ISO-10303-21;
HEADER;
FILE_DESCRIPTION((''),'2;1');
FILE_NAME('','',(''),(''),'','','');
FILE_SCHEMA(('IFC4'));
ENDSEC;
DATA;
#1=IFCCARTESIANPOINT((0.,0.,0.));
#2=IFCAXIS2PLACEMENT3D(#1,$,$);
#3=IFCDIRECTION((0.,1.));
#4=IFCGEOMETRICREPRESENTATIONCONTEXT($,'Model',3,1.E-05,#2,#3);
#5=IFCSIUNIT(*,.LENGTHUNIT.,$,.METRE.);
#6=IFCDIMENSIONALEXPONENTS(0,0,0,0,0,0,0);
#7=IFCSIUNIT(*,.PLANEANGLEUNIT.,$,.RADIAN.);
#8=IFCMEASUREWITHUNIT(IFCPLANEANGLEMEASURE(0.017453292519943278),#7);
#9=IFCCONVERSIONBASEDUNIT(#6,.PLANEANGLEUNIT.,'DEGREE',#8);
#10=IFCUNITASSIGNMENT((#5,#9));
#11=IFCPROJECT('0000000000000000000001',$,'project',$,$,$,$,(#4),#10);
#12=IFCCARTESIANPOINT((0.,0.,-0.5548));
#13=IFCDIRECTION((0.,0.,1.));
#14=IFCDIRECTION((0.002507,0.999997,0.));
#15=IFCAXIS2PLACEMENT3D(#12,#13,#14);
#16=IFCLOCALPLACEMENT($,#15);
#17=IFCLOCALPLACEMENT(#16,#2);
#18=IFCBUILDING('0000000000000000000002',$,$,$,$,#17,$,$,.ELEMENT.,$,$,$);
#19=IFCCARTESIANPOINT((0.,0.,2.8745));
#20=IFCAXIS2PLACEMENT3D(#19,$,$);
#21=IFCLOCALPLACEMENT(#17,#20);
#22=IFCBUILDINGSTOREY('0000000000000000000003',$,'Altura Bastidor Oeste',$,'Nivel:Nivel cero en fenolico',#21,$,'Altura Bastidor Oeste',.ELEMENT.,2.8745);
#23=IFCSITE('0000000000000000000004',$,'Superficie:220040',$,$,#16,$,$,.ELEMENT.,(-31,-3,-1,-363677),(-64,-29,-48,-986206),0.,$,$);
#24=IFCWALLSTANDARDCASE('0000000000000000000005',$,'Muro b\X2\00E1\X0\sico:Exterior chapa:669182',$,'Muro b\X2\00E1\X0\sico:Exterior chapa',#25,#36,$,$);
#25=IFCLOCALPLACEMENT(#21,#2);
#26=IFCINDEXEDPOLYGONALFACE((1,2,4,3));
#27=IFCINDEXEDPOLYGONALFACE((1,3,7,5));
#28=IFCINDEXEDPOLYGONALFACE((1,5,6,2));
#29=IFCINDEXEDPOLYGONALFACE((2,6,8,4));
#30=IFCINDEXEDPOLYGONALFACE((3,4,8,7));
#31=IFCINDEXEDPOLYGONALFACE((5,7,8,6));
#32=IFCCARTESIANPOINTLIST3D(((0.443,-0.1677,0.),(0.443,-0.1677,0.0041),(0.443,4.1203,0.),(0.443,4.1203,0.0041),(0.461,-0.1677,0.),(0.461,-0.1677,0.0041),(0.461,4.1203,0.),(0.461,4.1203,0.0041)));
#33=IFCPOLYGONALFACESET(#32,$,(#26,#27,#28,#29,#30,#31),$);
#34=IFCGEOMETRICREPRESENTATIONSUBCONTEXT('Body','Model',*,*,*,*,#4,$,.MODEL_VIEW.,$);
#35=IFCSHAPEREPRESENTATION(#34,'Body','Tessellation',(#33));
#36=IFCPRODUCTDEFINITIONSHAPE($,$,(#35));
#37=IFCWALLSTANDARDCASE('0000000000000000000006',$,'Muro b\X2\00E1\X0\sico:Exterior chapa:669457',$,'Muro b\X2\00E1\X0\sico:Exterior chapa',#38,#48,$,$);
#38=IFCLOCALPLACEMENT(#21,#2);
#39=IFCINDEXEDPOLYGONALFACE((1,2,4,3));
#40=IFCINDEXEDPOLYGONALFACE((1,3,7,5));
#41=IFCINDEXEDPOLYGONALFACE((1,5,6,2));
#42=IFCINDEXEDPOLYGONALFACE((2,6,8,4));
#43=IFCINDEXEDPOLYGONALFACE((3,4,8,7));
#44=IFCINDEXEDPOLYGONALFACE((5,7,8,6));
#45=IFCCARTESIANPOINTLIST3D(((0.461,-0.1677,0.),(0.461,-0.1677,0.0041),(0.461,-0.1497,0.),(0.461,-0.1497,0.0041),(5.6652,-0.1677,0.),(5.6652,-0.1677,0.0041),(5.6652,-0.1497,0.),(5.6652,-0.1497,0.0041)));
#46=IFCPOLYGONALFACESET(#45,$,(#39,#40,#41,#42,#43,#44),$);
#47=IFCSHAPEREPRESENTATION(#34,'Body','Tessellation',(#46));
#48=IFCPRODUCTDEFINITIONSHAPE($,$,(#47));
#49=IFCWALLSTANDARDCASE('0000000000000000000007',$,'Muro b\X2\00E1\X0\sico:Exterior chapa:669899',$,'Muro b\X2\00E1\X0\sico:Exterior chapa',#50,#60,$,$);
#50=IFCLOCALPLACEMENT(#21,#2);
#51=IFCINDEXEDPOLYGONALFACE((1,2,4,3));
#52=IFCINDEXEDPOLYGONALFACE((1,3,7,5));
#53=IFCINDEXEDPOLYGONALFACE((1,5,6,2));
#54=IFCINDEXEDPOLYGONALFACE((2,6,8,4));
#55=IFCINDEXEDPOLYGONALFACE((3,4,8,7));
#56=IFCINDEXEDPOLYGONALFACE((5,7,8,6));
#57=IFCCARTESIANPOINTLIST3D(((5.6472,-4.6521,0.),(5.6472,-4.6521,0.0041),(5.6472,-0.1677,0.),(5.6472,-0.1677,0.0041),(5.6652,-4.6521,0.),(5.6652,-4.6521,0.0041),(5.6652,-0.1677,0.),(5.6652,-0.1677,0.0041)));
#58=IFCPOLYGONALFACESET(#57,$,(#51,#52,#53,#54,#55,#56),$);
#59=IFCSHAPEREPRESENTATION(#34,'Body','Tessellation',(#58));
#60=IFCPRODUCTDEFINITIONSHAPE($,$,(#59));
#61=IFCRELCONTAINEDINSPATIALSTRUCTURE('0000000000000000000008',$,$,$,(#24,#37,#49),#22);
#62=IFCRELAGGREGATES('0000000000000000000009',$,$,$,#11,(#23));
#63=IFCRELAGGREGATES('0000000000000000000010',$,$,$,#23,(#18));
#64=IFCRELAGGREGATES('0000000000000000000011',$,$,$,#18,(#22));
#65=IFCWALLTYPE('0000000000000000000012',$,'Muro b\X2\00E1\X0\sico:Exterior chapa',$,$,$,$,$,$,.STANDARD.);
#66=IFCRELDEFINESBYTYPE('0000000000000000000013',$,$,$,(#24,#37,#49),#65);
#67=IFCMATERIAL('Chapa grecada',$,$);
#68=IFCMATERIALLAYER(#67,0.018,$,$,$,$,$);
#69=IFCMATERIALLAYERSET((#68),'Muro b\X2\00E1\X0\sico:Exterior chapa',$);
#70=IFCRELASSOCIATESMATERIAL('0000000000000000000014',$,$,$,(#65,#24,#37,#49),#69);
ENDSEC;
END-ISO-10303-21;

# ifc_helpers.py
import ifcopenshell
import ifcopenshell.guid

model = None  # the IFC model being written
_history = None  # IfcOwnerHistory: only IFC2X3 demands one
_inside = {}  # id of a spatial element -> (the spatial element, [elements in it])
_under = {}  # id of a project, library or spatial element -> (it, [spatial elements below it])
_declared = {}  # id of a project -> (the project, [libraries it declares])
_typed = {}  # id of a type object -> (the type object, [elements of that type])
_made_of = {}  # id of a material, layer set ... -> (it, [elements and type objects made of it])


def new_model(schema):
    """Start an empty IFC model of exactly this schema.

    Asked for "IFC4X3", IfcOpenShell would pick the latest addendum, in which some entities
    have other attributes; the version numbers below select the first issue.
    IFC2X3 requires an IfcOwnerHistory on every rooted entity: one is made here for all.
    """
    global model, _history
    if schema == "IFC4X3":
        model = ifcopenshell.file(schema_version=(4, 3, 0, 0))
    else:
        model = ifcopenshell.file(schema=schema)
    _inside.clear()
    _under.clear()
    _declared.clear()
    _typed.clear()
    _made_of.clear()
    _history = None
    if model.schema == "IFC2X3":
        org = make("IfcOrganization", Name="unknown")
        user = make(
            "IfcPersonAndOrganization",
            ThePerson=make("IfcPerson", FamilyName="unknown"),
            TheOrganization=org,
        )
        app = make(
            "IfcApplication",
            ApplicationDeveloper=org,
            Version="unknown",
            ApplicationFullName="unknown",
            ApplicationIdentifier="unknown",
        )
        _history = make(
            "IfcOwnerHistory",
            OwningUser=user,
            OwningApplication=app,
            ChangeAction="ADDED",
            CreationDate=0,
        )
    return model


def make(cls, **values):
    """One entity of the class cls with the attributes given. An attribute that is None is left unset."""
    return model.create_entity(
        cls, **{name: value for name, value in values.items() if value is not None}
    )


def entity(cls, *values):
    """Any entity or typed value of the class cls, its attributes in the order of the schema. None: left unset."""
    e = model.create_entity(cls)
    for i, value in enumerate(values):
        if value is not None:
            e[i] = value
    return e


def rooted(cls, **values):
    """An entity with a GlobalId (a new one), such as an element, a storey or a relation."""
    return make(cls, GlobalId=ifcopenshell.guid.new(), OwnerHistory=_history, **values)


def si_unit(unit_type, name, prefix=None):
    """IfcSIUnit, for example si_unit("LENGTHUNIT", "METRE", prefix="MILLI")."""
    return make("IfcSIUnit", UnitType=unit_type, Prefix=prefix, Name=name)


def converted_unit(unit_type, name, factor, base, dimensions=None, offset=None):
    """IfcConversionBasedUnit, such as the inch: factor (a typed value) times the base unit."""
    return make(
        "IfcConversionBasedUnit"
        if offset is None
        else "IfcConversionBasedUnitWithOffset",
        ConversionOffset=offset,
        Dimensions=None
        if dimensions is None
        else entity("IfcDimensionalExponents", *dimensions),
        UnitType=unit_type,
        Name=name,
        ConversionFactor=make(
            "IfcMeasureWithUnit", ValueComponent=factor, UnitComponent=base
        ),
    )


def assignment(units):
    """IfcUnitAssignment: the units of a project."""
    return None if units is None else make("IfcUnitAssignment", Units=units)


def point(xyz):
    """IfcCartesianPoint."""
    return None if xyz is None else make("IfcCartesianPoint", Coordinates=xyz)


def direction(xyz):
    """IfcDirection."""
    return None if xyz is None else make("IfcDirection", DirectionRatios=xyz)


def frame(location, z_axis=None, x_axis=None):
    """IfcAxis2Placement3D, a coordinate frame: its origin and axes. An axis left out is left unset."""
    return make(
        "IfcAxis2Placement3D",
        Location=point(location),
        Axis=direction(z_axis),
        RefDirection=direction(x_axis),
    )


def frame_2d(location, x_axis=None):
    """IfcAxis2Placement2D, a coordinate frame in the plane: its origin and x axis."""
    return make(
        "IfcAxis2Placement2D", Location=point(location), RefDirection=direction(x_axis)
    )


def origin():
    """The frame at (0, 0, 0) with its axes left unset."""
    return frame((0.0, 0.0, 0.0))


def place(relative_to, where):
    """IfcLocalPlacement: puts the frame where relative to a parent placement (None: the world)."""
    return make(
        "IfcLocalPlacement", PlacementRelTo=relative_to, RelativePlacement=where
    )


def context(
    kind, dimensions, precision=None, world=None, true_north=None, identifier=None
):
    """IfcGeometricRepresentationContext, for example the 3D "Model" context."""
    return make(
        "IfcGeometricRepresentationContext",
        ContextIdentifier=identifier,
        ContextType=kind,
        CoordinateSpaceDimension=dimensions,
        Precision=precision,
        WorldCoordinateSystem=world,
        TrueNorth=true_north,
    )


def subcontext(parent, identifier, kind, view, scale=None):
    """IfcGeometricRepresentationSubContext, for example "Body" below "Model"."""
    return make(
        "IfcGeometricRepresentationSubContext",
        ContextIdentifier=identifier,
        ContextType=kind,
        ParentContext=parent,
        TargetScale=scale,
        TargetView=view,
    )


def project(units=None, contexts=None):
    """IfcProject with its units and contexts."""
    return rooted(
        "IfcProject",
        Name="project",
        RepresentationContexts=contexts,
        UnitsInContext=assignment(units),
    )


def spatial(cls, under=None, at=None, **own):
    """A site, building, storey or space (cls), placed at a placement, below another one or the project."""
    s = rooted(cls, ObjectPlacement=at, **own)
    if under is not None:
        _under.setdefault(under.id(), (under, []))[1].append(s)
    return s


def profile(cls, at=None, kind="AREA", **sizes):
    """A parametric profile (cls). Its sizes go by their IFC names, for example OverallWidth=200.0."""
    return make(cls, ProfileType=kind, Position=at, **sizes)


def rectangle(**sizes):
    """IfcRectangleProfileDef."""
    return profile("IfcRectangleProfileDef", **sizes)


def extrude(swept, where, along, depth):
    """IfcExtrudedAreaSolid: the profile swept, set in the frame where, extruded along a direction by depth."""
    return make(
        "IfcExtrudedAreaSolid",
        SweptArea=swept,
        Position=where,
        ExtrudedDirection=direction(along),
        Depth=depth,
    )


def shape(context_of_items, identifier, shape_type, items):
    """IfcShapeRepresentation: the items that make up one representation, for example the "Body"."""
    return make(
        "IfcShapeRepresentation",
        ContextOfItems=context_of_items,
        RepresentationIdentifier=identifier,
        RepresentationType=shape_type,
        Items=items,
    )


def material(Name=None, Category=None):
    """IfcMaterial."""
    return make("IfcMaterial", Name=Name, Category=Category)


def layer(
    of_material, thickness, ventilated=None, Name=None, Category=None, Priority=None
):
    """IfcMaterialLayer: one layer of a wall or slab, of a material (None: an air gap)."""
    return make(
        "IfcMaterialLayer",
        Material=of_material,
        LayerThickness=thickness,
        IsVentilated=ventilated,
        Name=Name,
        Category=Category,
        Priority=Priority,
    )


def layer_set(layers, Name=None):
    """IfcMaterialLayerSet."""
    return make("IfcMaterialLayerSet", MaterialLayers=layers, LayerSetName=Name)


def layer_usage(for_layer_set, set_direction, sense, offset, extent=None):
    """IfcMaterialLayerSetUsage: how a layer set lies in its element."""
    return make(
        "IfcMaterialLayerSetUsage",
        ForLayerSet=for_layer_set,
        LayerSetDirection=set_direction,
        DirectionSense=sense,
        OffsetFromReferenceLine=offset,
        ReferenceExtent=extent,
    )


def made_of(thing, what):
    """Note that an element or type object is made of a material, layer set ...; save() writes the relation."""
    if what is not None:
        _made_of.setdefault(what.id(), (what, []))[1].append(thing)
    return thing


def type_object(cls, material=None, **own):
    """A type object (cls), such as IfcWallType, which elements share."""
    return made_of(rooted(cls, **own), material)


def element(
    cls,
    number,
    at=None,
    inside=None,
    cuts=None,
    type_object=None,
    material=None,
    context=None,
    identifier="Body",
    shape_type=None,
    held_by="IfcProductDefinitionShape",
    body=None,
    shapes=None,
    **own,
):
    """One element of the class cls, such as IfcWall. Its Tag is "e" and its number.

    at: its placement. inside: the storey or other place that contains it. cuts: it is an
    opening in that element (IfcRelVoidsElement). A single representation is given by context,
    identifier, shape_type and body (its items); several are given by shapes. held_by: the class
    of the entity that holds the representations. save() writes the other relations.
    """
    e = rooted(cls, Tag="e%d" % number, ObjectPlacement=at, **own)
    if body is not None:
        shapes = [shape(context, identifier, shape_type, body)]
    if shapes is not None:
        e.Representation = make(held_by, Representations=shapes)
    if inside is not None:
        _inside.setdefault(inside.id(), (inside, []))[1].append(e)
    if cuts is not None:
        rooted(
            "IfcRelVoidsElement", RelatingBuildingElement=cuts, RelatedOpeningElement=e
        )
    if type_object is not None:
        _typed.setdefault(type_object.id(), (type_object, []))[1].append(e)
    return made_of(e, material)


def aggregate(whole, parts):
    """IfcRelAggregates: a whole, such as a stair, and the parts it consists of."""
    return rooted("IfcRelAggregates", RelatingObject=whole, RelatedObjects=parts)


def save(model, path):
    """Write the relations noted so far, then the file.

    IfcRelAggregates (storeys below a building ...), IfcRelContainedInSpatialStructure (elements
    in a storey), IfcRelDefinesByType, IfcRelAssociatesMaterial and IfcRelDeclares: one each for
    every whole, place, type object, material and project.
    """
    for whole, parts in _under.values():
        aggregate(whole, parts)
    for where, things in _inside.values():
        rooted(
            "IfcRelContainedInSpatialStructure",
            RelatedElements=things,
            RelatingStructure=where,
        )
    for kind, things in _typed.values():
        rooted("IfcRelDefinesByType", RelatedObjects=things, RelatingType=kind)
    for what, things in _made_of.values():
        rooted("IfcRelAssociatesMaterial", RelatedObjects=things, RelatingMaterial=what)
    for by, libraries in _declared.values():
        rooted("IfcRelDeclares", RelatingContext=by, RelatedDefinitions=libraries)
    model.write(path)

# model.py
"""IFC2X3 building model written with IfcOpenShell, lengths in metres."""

from ifc_helpers import new_model, entity, si_unit, converted_unit, direction, frame, frame_2d, origin, place, context, subcontext, project, spatial, rectangle, extrude, material, layer, layer_set, layer_usage, type_object, element, save


model = new_model("IFC2X3")

# Units and contexts
model_context = context("Model", 3, precision=1e-05, world=origin(), true_north=direction((0.0, 1.0)))
body_context = subcontext(model_context, "Body", "Model", "MODEL_VIEW")
ifc_project = project(units=[si_unit("LENGTHUNIT", "METRE"), converted_unit("PLANEANGLEUNIT", "DEGREE", entity("IfcPlaneAngleMeasure", 0.017453292519943278), si_unit("PLANEANGLEUNIT", "RADIAN"), dimensions=[0, 0, 0, 0, 0, 0, 0])], contexts=[model_context])

# Site, building, storey
site_placement = place(None, frame((0.0, 0.0, -0.5548), z_axis=(0.0, 0.0, 1.0), x_axis=(0.002507, 0.999997, 0.0)))
site = spatial("IfcSite", under=ifc_project, at=site_placement, Name="Superficie:220040", CompositionType="ELEMENT", RefLatitude=(-31, -3, -1, -363677), RefLongitude=(-64, -29, -48, -986206), RefElevation=0.0)
building_placement = place(site_placement, origin())
building = spatial("IfcBuilding", under=site, at=building_placement, CompositionType="ELEMENT")
storey_placement = place(building_placement, frame((0.0, 0.0, 2.8745)))
storey = spatial("IfcBuildingStorey", under=building, at=storey_placement, Name="Altura Bastidor Oeste", ObjectType="Nivel:Nivel cero en fenolico", LongName="Altura Bastidor Oeste", CompositionType="ELEMENT", Elevation=2.8745)

# Walls
ifc_material_1 = material(Name="Chapa grecada")
ifc_layer_1 = layer(ifc_material_1, 0.018)
ifc_layer_set_1 = layer_set([ifc_layer_1], Name="Muro básico:Exterior chapa")
ifc_layer_usage_1 = layer_usage(ifc_layer_set_1, "AXIS2", "POSITIVE", -0.009)
wall_type_1 = type_object("IfcWallType", Name="Muro básico:Exterior chapa", PredefinedType="STANDARD", material=ifc_layer_set_1)
wall_1_placement = place(storey_placement, frame((0.452, 4.1203, 0.0), z_axis=(0.0, 0.0, 1.0), x_axis=(0.0, -1.0, 0.0)))
element("IfcWallStandardCase", 1, at=wall_1_placement, inside=storey, type_object=wall_type_1, material=ifc_layer_usage_1, Name="Muro básico:Exterior chapa:669182", ObjectType="Muro básico:Exterior chapa", context=body_context, shape_type="SweptSolid", body=[
    extrude(rectangle(XDim=0.018, YDim=4.288, at=frame_2d((0.0, 0.0), x_axis=(1.0, 0.0))), frame((2.144, 0.0, 0.0), z_axis=(0.0, 0.0, 1.0), x_axis=(0.0, 1.0, 0.0)), (0.0, 0.0, 1.0), 0.0041),
])
wall_2_placement = place(storey_placement, frame((0.461, -0.1587, 0.0)))
element("IfcWallStandardCase", 2, at=wall_2_placement, inside=storey, type_object=wall_type_1, material=ifc_layer_usage_1, Name="Muro básico:Exterior chapa:669457", ObjectType="Muro básico:Exterior chapa", context=body_context, shape_type="SweptSolid", body=[
    extrude(rectangle(XDim=0.018, YDim=5.2042, at=frame_2d((0.0, 0.0), x_axis=(1.0, 0.0))), frame((2.6021, 0.0, 0.0), z_axis=(0.0, 0.0, 1.0), x_axis=(0.0, 1.0, 0.0)), (0.0, 0.0, 1.0), 0.0041),
])
wall_3_placement = place(storey_placement, frame((5.6562, -0.1677, 0.0), z_axis=(0.0, 0.0, 1.0), x_axis=(0.0, -1.0, 0.0)))
element("IfcWallStandardCase", 3, at=wall_3_placement, inside=storey, type_object=wall_type_1, material=ifc_layer_usage_1, Name="Muro básico:Exterior chapa:669899", ObjectType="Muro básico:Exterior chapa", context=body_context, shape_type="SweptSolid", body=[
    extrude(rectangle(XDim=0.018, YDim=4.4844, at=frame_2d((0.0, 0.0), x_axis=(1.0, 0.0))), frame((2.2422, 0.0, 0.0), z_axis=(0.0, 0.0, 1.0), x_axis=(0.0, 1.0, 0.0)), (0.0, 0.0, 1.0), 0.0041),
])

save(model, "model.ifc")
